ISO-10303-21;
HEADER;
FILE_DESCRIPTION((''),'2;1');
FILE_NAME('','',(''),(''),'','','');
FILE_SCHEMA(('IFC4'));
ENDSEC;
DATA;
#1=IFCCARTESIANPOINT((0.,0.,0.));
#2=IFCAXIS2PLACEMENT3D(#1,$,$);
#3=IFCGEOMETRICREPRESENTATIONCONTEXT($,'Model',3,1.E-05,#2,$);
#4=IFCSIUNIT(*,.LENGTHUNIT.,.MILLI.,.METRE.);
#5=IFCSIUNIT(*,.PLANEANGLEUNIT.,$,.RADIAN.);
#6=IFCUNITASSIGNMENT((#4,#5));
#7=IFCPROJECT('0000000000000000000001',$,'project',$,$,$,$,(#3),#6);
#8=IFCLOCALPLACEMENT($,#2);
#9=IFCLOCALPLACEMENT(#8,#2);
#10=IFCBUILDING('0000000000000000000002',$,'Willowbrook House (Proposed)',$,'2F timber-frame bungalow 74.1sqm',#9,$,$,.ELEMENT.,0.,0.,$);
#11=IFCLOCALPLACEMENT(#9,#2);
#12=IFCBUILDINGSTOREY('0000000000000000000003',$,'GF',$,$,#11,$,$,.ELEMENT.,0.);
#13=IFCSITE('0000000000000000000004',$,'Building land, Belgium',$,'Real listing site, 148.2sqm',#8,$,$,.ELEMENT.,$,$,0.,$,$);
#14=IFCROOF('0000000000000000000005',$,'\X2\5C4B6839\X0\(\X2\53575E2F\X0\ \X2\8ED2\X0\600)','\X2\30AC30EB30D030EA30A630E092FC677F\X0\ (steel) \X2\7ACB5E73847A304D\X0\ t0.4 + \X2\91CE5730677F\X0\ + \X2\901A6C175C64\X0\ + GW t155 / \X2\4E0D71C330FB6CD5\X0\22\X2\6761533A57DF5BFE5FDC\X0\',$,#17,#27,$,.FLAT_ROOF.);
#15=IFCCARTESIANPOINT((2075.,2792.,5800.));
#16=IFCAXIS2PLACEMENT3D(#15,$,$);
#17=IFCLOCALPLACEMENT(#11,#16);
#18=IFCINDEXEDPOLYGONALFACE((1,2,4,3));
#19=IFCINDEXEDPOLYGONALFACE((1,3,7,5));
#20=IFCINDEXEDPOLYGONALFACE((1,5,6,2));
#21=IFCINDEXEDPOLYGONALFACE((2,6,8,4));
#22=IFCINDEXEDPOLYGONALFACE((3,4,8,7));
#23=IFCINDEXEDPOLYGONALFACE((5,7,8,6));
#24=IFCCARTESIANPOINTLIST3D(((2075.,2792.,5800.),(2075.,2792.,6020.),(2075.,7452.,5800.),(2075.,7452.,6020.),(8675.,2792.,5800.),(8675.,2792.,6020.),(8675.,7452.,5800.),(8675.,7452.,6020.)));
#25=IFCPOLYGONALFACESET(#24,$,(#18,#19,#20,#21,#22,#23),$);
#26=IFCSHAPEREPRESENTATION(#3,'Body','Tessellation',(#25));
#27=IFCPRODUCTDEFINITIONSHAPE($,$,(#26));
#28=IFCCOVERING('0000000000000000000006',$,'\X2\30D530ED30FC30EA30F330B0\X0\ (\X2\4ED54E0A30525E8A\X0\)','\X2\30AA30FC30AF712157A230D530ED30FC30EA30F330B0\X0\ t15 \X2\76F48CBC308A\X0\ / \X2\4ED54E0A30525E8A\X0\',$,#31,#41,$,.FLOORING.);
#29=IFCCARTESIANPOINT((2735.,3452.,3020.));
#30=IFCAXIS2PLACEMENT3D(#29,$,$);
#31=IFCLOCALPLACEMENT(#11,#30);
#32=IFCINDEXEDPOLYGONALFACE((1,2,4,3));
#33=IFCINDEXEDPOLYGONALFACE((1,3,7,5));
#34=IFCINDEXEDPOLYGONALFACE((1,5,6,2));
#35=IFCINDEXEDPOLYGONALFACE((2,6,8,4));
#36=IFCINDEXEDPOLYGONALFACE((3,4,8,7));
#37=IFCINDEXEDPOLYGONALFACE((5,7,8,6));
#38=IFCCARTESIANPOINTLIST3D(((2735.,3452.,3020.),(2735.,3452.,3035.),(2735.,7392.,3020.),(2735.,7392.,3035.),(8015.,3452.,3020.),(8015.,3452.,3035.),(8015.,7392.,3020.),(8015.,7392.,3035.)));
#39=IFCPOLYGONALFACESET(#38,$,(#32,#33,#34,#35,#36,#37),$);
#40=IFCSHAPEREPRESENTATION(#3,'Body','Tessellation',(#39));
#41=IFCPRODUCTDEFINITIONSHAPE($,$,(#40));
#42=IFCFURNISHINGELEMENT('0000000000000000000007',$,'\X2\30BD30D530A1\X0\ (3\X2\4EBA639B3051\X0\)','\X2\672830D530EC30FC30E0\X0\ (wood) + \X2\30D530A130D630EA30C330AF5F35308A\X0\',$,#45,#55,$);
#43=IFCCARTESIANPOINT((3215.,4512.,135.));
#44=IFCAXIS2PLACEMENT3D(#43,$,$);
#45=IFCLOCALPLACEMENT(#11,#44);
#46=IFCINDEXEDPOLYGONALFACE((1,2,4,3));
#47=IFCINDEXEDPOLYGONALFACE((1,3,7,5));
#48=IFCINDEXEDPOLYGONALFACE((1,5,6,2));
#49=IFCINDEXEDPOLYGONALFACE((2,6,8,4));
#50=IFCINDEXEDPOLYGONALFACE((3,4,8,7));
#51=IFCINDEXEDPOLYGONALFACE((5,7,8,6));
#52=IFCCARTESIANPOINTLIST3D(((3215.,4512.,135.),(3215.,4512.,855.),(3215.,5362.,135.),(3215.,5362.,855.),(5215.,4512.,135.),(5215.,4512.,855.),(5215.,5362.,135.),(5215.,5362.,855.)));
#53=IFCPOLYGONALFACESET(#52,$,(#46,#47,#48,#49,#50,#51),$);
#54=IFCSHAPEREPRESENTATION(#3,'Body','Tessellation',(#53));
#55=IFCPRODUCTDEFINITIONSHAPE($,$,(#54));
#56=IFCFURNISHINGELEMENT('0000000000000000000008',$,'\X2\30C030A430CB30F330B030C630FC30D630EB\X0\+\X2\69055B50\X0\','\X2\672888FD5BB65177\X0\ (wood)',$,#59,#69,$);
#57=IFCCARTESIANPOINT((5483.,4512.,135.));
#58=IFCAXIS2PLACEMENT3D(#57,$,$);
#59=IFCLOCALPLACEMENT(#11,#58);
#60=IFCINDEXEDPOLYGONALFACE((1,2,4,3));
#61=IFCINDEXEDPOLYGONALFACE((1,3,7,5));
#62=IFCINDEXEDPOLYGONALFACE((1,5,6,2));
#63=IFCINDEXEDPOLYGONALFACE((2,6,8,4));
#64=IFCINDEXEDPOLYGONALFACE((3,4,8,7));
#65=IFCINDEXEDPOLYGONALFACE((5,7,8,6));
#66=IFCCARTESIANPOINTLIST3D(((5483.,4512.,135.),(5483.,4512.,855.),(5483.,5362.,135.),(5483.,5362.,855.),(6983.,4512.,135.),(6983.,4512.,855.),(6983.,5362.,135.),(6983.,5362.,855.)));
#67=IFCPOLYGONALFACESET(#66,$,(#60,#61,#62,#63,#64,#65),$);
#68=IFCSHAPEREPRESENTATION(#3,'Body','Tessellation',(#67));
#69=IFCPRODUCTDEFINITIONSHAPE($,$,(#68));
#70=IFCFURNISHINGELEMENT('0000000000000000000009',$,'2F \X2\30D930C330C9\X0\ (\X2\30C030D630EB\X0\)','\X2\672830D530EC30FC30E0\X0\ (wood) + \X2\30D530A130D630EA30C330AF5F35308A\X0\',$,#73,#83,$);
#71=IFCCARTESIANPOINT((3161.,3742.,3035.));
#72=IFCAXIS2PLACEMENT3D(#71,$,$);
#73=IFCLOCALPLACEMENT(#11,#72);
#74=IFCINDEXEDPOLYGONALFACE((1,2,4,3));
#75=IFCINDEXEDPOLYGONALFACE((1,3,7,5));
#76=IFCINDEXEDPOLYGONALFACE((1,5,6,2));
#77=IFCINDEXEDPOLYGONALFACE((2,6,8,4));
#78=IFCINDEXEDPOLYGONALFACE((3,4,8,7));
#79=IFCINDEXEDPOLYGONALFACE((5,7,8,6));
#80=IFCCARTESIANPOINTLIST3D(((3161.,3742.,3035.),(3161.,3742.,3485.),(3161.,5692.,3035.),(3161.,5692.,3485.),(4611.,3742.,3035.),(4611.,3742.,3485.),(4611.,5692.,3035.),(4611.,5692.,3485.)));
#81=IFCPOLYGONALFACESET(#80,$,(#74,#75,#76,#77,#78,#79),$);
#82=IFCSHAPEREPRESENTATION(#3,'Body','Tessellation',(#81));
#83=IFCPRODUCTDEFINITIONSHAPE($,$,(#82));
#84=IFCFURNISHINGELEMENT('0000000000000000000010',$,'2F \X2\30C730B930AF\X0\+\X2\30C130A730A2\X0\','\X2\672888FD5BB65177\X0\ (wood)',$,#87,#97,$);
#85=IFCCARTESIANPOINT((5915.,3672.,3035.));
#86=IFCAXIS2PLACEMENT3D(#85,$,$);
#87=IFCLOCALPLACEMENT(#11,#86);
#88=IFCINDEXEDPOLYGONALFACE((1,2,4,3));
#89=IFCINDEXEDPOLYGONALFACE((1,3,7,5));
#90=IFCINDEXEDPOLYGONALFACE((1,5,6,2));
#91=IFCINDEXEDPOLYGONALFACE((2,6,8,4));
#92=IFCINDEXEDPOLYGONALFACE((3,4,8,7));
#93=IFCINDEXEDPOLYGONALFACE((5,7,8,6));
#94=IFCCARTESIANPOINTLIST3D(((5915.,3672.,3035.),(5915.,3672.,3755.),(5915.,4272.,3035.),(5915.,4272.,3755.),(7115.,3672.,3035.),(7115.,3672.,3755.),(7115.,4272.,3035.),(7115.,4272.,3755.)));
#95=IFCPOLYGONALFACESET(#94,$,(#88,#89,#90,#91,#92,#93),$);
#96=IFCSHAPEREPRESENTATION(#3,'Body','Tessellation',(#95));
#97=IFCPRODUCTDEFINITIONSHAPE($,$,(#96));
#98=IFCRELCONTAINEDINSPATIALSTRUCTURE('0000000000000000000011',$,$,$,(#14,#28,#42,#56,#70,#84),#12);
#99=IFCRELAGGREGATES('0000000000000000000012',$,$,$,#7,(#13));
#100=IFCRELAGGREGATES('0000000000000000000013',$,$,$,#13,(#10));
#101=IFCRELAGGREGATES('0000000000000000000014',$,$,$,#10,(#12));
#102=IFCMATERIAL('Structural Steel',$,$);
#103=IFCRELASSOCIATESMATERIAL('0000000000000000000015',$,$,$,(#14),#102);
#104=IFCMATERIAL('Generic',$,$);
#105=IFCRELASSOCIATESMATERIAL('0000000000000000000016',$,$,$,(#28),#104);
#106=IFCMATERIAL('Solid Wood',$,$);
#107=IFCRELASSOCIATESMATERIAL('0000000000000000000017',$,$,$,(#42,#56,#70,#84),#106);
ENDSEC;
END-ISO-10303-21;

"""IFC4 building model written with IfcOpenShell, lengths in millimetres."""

from ifc_helpers import new_model, si_unit, frame, frame_2d, origin, place, context, project, spatial, rectangle, extrude, material, element, save


model = new_model("IFC4")

# Units and contexts
model_context = context("Model", 3, precision=1e-05, world=origin())
ifc_project = project(units=[si_unit("LENGTHUNIT", "METRE", prefix="MILLI"), si_unit("PLANEANGLEUNIT", "RADIAN")], contexts=[model_context])

# Site, building, storey
site_placement = place(None, origin())
site = spatial("IfcSite", under=ifc_project, at=site_placement, Name="Building land, Belgium", ObjectType="Real listing site, 148.2sqm", CompositionType="ELEMENT", RefElevation=0.0)
building_placement = place(site_placement, origin())
building = spatial("IfcBuilding", under=site, at=building_placement, Name="Willowbrook House (Proposed)", ObjectType="2F timber-frame bungalow 74.1sqm", CompositionType="ELEMENT", ElevationOfRefHeight=0.0, ElevationOfTerrain=0.0)
storey_placement = place(building_placement, origin())
storey = spatial("IfcBuildingStorey", under=building, at=storey_placement, Name="GF", CompositionType="ELEMENT", Elevation=0.0)

# Shared definitions
ifc_material_1 = material(Name="Solid Wood")

# Roof
ifc_material_2 = material(Name="Structural Steel")
for number, where, name in (
    (1, (2075.0, 2792.0, 5800.0), "屋根(南帯 軒600)"),
):
    element("IfcRoof", number, at=place(storey_placement, frame(where)), inside=storey, material=ifc_material_2, Name=name, Description="ガルバリウム鋼板 (steel) 立平葺き t0.4 + 野地板 + 通気層 + GW t155 / 不燃・法22条区域対応", PredefinedType="FLAT_ROOF", context=model_context, shape_type="SweptSolid", body=[
        extrude(rectangle(XDim=6600.0, YDim=4660.0, at=frame_2d((3300.0, 2330.0))), frame((2075.0, 2792.0, 5800.0)), (0.0, 0.0, 1.0), 220.0),
    ])

# Covering
ifc_material_3 = material(Name="Generic")
covering_placement = place(storey_placement, frame((2735.0, 3452.0, 3020.0)))
element("IfcCovering", 2, at=covering_placement, inside=storey, material=ifc_material_3, Name="フローリング (仕上げ床)", Description="オーク無垢フローリング t15 直貼り / 仕上げ床", PredefinedType="FLOORING", context=model_context, shape_type="SweptSolid", body=[
    extrude(rectangle(XDim=5280.0, YDim=3940.0, at=frame_2d((2640.0, 1970.0))), frame((2735.0, 3452.0, 3020.0)), (0.0, 0.0, 1.0), 15.0),
])

# Furnishing elements
furnishing_1_placement = place(storey_placement, frame((3215.0, 4512.0, 135.0)))
element("IfcFurnishingElement", 3, at=furnishing_1_placement, inside=storey, material=ifc_material_1, Name="ソファ (3人掛け)", Description="木フレーム (wood) + ファブリック張り", context=model_context, shape_type="SweptSolid", body=[
    extrude(rectangle(XDim=2000.0, YDim=850.0, at=frame_2d((1000.0, 425.0))), frame((3215.0, 4512.0, 135.0)), (0.0, 0.0, 1.0), 720.0),
])
furnishing_2_placement = place(storey_placement, frame((5483.0, 4512.0, 135.0)))
element("IfcFurnishingElement", 4, at=furnishing_2_placement, inside=storey, material=ifc_material_1, Name="ダイニングテーブル+椅子", Description="木製家具 (wood)", context=model_context, shape_type="SweptSolid", body=[
    extrude(rectangle(XDim=1500.0, YDim=850.0, at=frame_2d((750.0, 425.0))), frame((5483.0, 4512.0, 135.0)), (0.0, 0.0, 1.0), 720.0),
])
furnishing_3_placement = place(storey_placement, frame((3161.0, 3742.0, 3035.0)))
element("IfcFurnishingElement", 5, at=furnishing_3_placement, inside=storey, material=ifc_material_1, Name="2F ベッド (ダブル)", Description="木フレーム (wood) + ファブリック張り", context=model_context, shape_type="SweptSolid", body=[
    extrude(rectangle(XDim=1450.0, YDim=1950.0, at=frame_2d((725.0, 975.0))), frame((3161.0, 3742.0, 3035.0)), (0.0, 0.0, 1.0), 450.0),
])
furnishing_4_placement = place(storey_placement, frame((5915.0, 3672.0, 3035.0)))
element("IfcFurnishingElement", 6, at=furnishing_4_placement, inside=storey, material=ifc_material_1, Name="2F デスク+チェア", Description="木製家具 (wood)", context=model_context, shape_type="SweptSolid", body=[
    extrude(rectangle(XDim=1200.0, YDim=600.0, at=frame_2d((600.0, 300.0))), frame((5915.0, 3672.0, 3035.0)), (0.0, 0.0, 1.0), 720.0),
])

save(model, "model.ifc")
